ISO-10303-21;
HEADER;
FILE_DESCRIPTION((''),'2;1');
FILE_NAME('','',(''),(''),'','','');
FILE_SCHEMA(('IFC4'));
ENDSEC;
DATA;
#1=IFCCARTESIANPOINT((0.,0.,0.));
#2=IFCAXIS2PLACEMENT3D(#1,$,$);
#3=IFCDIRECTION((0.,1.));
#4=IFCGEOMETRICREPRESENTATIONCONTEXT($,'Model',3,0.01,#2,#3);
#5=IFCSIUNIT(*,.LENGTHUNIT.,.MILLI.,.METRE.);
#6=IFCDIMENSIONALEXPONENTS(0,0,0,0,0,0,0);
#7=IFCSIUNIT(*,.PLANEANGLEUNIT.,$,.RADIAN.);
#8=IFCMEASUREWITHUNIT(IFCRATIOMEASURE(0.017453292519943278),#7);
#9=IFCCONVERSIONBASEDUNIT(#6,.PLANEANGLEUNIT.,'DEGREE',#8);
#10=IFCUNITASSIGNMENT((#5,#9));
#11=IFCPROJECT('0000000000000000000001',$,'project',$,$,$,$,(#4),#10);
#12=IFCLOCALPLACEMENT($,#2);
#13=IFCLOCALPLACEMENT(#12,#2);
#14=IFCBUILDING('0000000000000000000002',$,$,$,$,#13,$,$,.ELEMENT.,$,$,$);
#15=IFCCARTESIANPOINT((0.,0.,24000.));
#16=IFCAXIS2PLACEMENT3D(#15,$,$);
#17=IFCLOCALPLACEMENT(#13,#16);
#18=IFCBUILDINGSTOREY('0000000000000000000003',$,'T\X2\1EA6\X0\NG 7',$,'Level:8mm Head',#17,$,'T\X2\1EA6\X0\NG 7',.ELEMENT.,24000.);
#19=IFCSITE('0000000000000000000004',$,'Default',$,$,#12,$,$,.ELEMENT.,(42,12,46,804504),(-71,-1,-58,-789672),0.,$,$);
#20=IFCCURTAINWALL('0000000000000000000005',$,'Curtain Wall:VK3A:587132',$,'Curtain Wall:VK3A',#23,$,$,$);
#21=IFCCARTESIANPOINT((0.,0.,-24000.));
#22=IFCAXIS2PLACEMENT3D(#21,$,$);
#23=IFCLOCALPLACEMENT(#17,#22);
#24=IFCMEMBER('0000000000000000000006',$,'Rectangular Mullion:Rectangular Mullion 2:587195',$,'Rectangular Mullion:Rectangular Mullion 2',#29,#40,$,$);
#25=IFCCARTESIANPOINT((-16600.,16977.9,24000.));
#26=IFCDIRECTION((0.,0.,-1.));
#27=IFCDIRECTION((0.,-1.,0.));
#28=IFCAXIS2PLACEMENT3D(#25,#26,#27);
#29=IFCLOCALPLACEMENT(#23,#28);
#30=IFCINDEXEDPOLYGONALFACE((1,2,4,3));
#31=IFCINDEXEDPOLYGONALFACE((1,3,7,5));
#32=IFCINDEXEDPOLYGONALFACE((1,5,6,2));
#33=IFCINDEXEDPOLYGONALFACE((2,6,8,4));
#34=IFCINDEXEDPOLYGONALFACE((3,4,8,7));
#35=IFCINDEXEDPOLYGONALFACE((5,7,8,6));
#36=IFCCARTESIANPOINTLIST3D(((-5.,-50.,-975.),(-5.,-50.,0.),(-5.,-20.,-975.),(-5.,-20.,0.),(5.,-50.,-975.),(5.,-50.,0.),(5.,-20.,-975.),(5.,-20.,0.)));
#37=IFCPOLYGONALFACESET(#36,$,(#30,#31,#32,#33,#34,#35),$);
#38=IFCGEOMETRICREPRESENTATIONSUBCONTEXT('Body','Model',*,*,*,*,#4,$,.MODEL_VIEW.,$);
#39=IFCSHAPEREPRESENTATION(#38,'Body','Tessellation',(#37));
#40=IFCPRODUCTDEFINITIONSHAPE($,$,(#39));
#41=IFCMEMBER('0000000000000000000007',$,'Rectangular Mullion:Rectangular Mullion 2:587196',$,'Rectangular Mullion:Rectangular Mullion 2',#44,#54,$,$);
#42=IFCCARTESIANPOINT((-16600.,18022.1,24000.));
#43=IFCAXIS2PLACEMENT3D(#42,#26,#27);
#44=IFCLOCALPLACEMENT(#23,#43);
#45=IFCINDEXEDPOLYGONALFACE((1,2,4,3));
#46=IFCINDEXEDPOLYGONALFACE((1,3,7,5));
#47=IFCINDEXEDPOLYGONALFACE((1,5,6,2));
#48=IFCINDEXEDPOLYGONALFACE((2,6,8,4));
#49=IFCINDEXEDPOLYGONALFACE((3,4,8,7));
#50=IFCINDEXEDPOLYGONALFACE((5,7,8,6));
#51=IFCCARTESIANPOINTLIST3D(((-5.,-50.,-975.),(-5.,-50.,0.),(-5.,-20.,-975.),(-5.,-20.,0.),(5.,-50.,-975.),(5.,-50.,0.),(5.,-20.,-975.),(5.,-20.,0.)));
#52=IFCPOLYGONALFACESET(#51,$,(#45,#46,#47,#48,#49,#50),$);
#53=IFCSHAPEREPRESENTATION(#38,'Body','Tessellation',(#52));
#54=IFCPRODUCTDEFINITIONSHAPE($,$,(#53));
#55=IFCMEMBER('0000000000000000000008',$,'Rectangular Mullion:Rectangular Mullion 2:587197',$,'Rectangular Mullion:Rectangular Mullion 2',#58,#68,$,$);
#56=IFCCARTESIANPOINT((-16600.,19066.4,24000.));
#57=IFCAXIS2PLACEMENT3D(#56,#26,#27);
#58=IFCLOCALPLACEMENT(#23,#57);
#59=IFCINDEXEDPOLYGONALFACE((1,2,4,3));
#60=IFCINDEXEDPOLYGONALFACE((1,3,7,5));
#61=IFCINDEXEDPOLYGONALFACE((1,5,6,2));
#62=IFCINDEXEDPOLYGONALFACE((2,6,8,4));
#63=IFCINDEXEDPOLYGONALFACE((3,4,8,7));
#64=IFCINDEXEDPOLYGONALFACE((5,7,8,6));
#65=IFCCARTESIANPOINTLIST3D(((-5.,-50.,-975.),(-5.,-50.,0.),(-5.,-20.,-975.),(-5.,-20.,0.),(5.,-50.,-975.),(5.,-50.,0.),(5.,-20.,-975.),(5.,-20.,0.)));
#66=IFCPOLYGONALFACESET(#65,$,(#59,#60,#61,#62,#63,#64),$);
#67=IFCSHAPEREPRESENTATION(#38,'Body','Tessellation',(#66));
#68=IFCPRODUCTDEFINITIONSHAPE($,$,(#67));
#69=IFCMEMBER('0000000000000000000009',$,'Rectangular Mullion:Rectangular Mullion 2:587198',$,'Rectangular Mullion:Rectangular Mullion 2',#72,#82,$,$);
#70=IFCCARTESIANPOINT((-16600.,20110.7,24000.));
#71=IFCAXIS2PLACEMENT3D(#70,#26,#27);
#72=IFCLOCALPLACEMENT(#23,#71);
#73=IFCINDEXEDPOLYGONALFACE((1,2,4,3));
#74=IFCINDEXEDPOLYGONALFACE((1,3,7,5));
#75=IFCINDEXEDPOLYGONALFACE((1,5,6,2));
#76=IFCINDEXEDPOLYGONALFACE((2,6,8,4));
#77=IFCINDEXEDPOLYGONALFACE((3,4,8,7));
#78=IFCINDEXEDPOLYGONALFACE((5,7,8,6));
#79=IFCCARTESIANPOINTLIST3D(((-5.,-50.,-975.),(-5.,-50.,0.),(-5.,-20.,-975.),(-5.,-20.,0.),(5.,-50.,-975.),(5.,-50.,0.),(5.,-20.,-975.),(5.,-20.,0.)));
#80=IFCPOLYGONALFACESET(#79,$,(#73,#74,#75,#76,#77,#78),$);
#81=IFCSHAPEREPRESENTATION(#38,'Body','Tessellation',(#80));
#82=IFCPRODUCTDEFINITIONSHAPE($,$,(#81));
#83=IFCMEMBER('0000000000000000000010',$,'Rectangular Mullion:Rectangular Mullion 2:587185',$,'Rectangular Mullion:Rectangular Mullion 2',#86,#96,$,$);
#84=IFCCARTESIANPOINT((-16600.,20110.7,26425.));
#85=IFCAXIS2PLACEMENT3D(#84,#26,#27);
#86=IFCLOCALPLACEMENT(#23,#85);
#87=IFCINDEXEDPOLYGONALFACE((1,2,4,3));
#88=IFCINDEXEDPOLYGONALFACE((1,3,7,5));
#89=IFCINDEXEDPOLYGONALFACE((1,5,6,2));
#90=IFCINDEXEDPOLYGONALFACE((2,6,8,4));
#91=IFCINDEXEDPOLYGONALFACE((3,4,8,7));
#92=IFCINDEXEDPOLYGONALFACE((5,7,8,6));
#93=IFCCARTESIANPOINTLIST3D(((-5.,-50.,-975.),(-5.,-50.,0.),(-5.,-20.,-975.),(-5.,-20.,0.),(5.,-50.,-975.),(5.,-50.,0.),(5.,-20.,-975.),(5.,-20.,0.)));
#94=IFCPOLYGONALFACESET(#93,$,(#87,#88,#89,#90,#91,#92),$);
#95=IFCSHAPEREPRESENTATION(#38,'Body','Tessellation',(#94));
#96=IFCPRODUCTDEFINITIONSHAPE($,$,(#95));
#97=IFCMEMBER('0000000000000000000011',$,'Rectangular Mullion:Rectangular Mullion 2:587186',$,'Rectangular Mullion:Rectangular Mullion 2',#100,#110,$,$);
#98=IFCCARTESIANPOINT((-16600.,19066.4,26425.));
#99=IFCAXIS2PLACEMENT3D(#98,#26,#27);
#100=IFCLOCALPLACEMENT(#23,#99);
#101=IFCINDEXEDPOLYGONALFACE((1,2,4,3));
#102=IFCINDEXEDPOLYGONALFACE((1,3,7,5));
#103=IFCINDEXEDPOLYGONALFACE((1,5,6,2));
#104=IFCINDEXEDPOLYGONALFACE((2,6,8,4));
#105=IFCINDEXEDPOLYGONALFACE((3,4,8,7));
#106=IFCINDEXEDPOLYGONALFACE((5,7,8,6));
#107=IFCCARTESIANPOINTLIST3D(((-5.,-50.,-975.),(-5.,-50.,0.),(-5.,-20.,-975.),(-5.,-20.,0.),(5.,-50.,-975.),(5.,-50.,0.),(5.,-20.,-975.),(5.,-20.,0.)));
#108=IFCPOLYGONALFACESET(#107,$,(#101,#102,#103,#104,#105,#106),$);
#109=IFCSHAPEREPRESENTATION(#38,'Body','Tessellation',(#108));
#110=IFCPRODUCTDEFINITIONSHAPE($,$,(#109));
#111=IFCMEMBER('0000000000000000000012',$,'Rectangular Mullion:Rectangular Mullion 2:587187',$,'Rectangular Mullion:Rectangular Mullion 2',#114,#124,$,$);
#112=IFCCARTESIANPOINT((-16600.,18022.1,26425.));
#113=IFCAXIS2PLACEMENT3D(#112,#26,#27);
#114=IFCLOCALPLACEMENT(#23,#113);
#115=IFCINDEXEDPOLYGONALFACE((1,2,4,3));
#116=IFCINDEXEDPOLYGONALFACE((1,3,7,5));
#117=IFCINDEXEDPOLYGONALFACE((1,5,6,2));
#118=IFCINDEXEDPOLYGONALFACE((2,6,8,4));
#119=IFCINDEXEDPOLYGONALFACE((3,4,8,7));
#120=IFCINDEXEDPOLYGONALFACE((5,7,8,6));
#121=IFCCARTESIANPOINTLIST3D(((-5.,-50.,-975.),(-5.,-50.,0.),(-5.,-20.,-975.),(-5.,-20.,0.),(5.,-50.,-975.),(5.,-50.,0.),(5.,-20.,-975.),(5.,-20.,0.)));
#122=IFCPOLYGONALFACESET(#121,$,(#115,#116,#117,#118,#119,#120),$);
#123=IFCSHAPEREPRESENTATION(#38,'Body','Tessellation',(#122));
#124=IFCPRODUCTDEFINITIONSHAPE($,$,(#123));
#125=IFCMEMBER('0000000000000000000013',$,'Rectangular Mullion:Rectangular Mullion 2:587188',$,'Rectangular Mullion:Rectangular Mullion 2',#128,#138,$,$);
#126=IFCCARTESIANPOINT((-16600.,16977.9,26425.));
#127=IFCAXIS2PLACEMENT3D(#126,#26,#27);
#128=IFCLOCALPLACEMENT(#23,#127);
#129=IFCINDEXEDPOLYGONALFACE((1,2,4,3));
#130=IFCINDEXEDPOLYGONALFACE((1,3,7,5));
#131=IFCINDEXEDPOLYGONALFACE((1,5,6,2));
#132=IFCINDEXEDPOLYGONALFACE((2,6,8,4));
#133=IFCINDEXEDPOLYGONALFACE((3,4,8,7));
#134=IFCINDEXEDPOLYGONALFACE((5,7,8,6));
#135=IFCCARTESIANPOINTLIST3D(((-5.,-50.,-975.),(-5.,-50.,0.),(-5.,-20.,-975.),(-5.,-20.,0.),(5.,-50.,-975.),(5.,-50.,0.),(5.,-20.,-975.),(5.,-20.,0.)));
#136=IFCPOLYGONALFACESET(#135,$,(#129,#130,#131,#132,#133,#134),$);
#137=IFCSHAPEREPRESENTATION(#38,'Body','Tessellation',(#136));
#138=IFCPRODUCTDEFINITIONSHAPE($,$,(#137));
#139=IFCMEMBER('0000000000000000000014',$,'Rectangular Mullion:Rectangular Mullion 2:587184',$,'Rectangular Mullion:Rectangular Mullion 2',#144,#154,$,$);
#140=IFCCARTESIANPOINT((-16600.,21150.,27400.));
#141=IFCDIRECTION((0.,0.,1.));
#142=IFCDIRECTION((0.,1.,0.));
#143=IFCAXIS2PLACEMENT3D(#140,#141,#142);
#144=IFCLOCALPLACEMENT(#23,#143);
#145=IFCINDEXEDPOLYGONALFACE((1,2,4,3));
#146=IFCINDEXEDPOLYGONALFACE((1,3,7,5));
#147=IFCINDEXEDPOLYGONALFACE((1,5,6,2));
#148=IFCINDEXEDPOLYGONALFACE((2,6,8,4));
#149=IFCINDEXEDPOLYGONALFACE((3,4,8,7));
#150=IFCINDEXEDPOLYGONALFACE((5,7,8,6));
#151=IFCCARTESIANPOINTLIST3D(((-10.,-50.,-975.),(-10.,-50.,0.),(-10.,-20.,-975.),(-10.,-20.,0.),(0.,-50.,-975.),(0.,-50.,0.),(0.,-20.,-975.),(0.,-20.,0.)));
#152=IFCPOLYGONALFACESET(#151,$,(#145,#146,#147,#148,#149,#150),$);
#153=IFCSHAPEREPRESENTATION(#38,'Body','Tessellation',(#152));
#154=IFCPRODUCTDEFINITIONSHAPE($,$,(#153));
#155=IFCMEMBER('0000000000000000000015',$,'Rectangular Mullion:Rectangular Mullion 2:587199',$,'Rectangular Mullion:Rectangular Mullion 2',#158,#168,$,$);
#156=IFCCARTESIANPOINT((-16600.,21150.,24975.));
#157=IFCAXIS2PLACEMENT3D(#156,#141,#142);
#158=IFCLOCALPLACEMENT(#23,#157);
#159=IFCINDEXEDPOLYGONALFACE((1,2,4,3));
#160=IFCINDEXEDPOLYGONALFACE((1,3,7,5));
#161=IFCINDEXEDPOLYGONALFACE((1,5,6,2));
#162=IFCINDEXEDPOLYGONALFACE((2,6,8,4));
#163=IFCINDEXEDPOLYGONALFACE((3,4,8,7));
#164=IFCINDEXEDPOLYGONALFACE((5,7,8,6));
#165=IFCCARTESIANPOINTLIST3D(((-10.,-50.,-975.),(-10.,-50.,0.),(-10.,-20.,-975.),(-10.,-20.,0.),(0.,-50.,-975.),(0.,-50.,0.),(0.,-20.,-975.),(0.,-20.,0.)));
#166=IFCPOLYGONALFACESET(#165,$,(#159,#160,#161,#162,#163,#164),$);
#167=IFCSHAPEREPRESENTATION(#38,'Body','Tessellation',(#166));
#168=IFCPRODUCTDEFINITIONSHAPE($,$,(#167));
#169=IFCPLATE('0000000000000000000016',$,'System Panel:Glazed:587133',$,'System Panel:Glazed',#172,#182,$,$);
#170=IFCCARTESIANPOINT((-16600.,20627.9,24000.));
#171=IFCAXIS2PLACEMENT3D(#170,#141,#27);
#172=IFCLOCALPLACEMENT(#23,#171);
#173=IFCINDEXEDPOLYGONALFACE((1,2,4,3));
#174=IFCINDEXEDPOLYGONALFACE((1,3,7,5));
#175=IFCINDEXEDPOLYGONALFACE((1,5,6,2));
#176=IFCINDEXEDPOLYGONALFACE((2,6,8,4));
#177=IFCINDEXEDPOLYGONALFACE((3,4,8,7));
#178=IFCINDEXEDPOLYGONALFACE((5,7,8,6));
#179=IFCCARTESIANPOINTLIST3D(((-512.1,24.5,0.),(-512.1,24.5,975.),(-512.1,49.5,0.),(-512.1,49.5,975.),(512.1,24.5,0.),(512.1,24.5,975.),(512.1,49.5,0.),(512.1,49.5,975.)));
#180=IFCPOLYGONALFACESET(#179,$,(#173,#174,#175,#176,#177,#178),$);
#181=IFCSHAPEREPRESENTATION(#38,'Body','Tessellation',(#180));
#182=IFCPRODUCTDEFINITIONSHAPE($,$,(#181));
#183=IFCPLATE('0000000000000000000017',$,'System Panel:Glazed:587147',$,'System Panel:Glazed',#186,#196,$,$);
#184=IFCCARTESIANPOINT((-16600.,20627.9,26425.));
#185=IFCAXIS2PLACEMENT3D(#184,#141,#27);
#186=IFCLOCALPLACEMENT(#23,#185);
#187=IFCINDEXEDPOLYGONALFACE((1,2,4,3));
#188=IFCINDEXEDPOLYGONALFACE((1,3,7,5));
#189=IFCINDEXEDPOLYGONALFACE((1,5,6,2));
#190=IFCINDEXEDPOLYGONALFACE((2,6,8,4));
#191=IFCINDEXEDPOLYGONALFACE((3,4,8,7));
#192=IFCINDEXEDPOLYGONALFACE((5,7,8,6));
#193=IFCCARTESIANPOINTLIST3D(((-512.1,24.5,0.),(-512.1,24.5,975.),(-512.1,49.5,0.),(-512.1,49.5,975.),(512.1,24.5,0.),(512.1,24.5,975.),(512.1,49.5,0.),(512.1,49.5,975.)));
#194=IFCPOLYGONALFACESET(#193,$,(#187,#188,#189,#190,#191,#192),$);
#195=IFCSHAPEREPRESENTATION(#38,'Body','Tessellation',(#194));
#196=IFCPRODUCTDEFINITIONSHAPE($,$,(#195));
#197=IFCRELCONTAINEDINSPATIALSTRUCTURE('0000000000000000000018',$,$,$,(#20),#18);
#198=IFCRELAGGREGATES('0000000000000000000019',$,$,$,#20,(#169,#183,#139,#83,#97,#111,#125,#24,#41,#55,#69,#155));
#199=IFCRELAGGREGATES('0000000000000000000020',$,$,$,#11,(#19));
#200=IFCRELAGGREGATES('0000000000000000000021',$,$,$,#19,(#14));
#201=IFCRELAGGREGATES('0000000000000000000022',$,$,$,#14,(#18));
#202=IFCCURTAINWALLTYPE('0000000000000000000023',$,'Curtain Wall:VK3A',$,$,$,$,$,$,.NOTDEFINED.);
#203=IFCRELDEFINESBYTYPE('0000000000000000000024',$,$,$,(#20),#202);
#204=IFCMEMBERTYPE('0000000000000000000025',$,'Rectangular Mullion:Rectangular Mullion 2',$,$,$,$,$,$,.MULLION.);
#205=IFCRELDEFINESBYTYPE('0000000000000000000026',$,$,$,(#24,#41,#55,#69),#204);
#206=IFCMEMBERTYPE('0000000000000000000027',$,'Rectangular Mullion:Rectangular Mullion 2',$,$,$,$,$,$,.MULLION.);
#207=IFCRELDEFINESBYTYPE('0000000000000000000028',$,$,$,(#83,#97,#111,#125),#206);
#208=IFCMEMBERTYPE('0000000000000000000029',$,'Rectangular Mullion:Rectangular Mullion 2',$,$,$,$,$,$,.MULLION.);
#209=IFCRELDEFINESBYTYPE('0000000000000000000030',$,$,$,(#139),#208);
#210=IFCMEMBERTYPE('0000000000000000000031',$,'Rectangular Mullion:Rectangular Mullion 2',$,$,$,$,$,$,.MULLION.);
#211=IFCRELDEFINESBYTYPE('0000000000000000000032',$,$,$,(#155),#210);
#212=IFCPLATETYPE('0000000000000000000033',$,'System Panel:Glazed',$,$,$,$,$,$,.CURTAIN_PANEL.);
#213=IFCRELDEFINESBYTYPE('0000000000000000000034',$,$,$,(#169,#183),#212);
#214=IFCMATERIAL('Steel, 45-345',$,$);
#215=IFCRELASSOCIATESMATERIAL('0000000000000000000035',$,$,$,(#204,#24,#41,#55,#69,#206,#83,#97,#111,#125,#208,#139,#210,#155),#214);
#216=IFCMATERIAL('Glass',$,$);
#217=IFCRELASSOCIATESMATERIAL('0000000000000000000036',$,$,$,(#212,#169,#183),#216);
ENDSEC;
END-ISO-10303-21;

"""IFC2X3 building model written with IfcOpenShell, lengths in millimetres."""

from ifc_helpers import new_model, entity, si_unit, converted_unit, direction, frame, frame_2d, origin, origin_2d_with_axis, place, context, subcontext, project, spatial, rectangle, extrude, source, transform, mapped, material, type_object, type_shapes, element, aggregate, save


model = new_model("IFC2X3")

# Units and contexts
model_context = context("Model", 3, precision=0.01, world=origin(), true_north=direction((0.0, 1.0)))
body_context = subcontext(model_context, "Body", "Model", "MODEL_VIEW")
ifc_project = project(units=[si_unit("LENGTHUNIT", "METRE", prefix="MILLI"), converted_unit("PLANEANGLEUNIT", "DEGREE", entity("IfcRatioMeasure", 0.017453292519943278), si_unit("PLANEANGLEUNIT", "RADIAN"), dimensions=[0, 0, 0, 0, 0, 0, 0])], contexts=[model_context])

# Site, building, storey
site_placement = place(None, origin())
site = spatial("IfcSite", under=ifc_project, at=site_placement, Name="Default", CompositionType="ELEMENT", RefLatitude=(42, 12, 46, 804504), RefLongitude=(-71, -1, -58, -789672), RefElevation=0.0)
building_placement = place(site_placement, origin())
building = spatial("IfcBuilding", under=site, at=building_placement, CompositionType="ELEMENT")
storey_placement = place(building_placement, frame((0.0, 0.0, 24000.0)))
storey = spatial("IfcBuildingStorey", under=building, at=storey_placement, Name="TẦNG 7", ObjectType="Level:8mm Head", LongName="TẦNG 7", CompositionType="ELEMENT", Elevation=24000.0)

# Curtain wall, members
curtain_wall_type_1 = type_object("IfcCurtainWallType", Name="Curtain Wall:VK3A", PredefinedType="NOTDEFINED")
curtain_wall_1_placement = place(storey_placement, frame((0.0, 0.0, -24000.0)))
curtain_wall_1 = element("IfcCurtainWall", 1, at=curtain_wall_1_placement, inside=storey, type_object=curtain_wall_type_1, Name="Curtain Wall:VK3A:587132", ObjectType="Curtain Wall:VK3A")
ifc_material_1 = material(Name="Steel, 45-345")
member_type_1 = type_object("IfcMemberType", Name="Rectangular Mullion:Rectangular Mullion 2", PredefinedType="MULLION", material=ifc_material_1)
shared_shape_1 = source(origin(), body_context, "Body", "SweptSolid", [
    extrude(rectangle(XDim=30.0, YDim=10.0, at=frame_2d((0.0, 0.0), x_axis=(1.0, 0.0))), frame((0.0, -35.0, -975.0), z_axis=(0.0, 0.0, 1.0), x_axis=(0.0, -1.0, 0.0)), (0.0, 0.0, 1.0), 975.0),
])
type_shapes(member_type_1, [shared_shape_1])
member_1_placement = place(curtain_wall_1_placement, frame((-16600.0, 16977.9, 24000.0), z_axis=(0.0, 0.0, -1.0), x_axis=(0.0, -1.0, 0.0)))
member_1 = element("IfcMember", 2, at=member_1_placement, type_object=member_type_1, material=ifc_material_1, Name="Rectangular Mullion:Rectangular Mullion 2:587195", ObjectType="Rectangular Mullion:Rectangular Mullion 2", context=body_context, shape_type="MappedRepresentation", body=[
    mapped(shared_shape_1, transform((0.0, 0.0, 0.0), scale=1.0)),
])
member_2_placement = place(curtain_wall_1_placement, frame((-16600.0, 18022.1, 24000.0), z_axis=(0.0, 0.0, -1.0), x_axis=(0.0, -1.0, 0.0)))
member_2 = element("IfcMember", 3, at=member_2_placement, type_object=member_type_1, material=ifc_material_1, Name="Rectangular Mullion:Rectangular Mullion 2:587196", ObjectType="Rectangular Mullion:Rectangular Mullion 2", context=body_context, shape_type="MappedRepresentation", body=[
    mapped(shared_shape_1, transform((0.0, 0.0, 0.0), scale=1.0)),
])
member_3_placement = place(curtain_wall_1_placement, frame((-16600.0, 19066.4, 24000.0), z_axis=(0.0, 0.0, -1.0), x_axis=(0.0, -1.0, 0.0)))
member_3 = element("IfcMember", 4, at=member_3_placement, type_object=member_type_1, material=ifc_material_1, Name="Rectangular Mullion:Rectangular Mullion 2:587197", ObjectType="Rectangular Mullion:Rectangular Mullion 2", context=body_context, shape_type="MappedRepresentation", body=[
    mapped(shared_shape_1, transform((0.0, 0.0, 0.0), scale=1.0)),
])
member_4_placement = place(curtain_wall_1_placement, frame((-16600.0, 20110.7, 24000.0), z_axis=(0.0, 0.0, -1.0), x_axis=(0.0, -1.0, 0.0)))
member_4 = element("IfcMember", 5, at=member_4_placement, type_object=member_type_1, material=ifc_material_1, Name="Rectangular Mullion:Rectangular Mullion 2:587198", ObjectType="Rectangular Mullion:Rectangular Mullion 2", context=body_context, shape_type="MappedRepresentation", body=[
    mapped(shared_shape_1, transform((0.0, 0.0, 0.0), scale=1.0)),
])

# Members
member_type_2 = type_object("IfcMemberType", Name="Rectangular Mullion:Rectangular Mullion 2", PredefinedType="MULLION", material=ifc_material_1)
shared_shape_2 = source(origin(), body_context, "Body", "SweptSolid", [
    extrude(rectangle(XDim=30.0, YDim=10.0, at=frame_2d((0.0, 0.0), x_axis=(1.0, 0.0))), frame((0.0, -35.0, -975.0), z_axis=(0.0, 0.0, 1.0), x_axis=(0.0, -1.0, 0.0)), (0.0, 0.0, 1.0), 975.0),
])
type_shapes(member_type_2, [shared_shape_2])
member_5_placement = place(curtain_wall_1_placement, frame((-16600.0, 20110.7, 26425.0), z_axis=(0.0, 0.0, -1.0), x_axis=(0.0, -1.0, 0.0)))
member_5 = element("IfcMember", 6, at=member_5_placement, type_object=member_type_2, material=ifc_material_1, Name="Rectangular Mullion:Rectangular Mullion 2:587185", ObjectType="Rectangular Mullion:Rectangular Mullion 2", context=body_context, shape_type="MappedRepresentation", body=[
    mapped(shared_shape_2, transform((0.0, 0.0, 0.0), scale=1.0)),
])
member_6_placement = place(curtain_wall_1_placement, frame((-16600.0, 19066.4, 26425.0), z_axis=(0.0, 0.0, -1.0), x_axis=(0.0, -1.0, 0.0)))
member_6 = element("IfcMember", 7, at=member_6_placement, type_object=member_type_2, material=ifc_material_1, Name="Rectangular Mullion:Rectangular Mullion 2:587186", ObjectType="Rectangular Mullion:Rectangular Mullion 2", context=body_context, shape_type="MappedRepresentation", body=[
    mapped(shared_shape_2, transform((0.0, 0.0, 0.0), scale=1.0)),
])
member_7_placement = place(curtain_wall_1_placement, frame((-16600.0, 18022.1, 26425.0), z_axis=(0.0, 0.0, -1.0), x_axis=(0.0, -1.0, 0.0)))
member_7 = element("IfcMember", 8, at=member_7_placement, type_object=member_type_2, material=ifc_material_1, Name="Rectangular Mullion:Rectangular Mullion 2:587187", ObjectType="Rectangular Mullion:Rectangular Mullion 2", context=body_context, shape_type="MappedRepresentation", body=[
    mapped(shared_shape_2, transform((0.0, 0.0, 0.0), scale=1.0)),
])
member_8_placement = place(curtain_wall_1_placement, frame((-16600.0, 16977.9, 26425.0), z_axis=(0.0, 0.0, -1.0), x_axis=(0.0, -1.0, 0.0)))
member_8 = element("IfcMember", 9, at=member_8_placement, type_object=member_type_2, material=ifc_material_1, Name="Rectangular Mullion:Rectangular Mullion 2:587188", ObjectType="Rectangular Mullion:Rectangular Mullion 2", context=body_context, shape_type="MappedRepresentation", body=[
    mapped(shared_shape_2, transform((0.0, 0.0, 0.0), scale=1.0)),
])
member_type_3 = type_object("IfcMemberType", Name="Rectangular Mullion:Rectangular Mullion 2", PredefinedType="MULLION", material=ifc_material_1)
shared_shape_3 = source(origin(), body_context, "Body", "SweptSolid", [
    extrude(rectangle(XDim=30.0, YDim=10.0, at=frame_2d((0.0, 0.0), x_axis=(1.0, 0.0))), frame((-5.0, -35.0, -975.0), z_axis=(0.0, 0.0, 1.0), x_axis=(0.0, -1.0, 0.0)), (0.0, 0.0, 1.0), 975.0),
])
type_shapes(member_type_3, [shared_shape_3])
member_9_placement = place(curtain_wall_1_placement, frame((-16600.0, 21150.0, 27400.0), z_axis=(0.0, 0.0, 1.0), x_axis=(0.0, 1.0, 0.0)))
member_9 = element("IfcMember", 10, at=member_9_placement, type_object=member_type_3, material=ifc_material_1, Name="Rectangular Mullion:Rectangular Mullion 2:587184", ObjectType="Rectangular Mullion:Rectangular Mullion 2", context=body_context, shape_type="MappedRepresentation", body=[
    mapped(shared_shape_3, transform((0.0, 0.0, 0.0), scale=1.0)),
])
member_type_4 = type_object("IfcMemberType", Name="Rectangular Mullion:Rectangular Mullion 2", PredefinedType="MULLION", material=ifc_material_1)
shared_shape_4 = source(origin(), body_context, "Body", "SweptSolid", [
    extrude(rectangle(XDim=30.0, YDim=10.0, at=frame_2d((0.0, 0.0), x_axis=(1.0, 0.0))), frame((-5.0, -35.0, -975.0), z_axis=(0.0, 0.0, 1.0), x_axis=(0.0, -1.0, 0.0)), (0.0, 0.0, 1.0), 975.0),
])
type_shapes(member_type_4, [shared_shape_4])
member_10_placement = place(curtain_wall_1_placement, frame((-16600.0, 21150.0, 24975.0), z_axis=(0.0, 0.0, 1.0), x_axis=(0.0, 1.0, 0.0)))
member_10 = element("IfcMember", 11, at=member_10_placement, type_object=member_type_4, material=ifc_material_1, Name="Rectangular Mullion:Rectangular Mullion 2:587199", ObjectType="Rectangular Mullion:Rectangular Mullion 2", context=body_context, shape_type="MappedRepresentation", body=[
    mapped(shared_shape_4, transform((0.0, 0.0, 0.0), scale=1.0)),
])

# Plates
ifc_material_2 = material(Name="Glass")
plate_type_1 = type_object("IfcPlateType", Name="System Panel:Glazed", PredefinedType="CURTAIN_PANEL", material=ifc_material_2)
shared_shape_5 = source(origin(), body_context, "Body", "SweptSolid", [
    extrude(rectangle(XDim=25.0, YDim=1024.3, at=origin_2d_with_axis()), frame((0.0, 37.0, 0.0), z_axis=(0.0, 0.0, 1.0), x_axis=(0.0, 1.0, 0.0)), (0.0, 0.0, 1.0), 975.0),
])
type_shapes(plate_type_1, [shared_shape_5])
plate_1_placement = place(curtain_wall_1_placement, frame((-16600.0, 20627.9, 24000.0), z_axis=(0.0, 0.0, 1.0), x_axis=(0.0, -1.0, 0.0)))
plate_1 = element("IfcPlate", 12, at=plate_1_placement, type_object=plate_type_1, material=ifc_material_2, Name="System Panel:Glazed:587133", ObjectType="System Panel:Glazed", context=body_context, shape_type="MappedRepresentation", body=[
    mapped(shared_shape_5, transform((0.0, 0.0, 0.0), scale=1.0)),
])
plate_2_placement = place(curtain_wall_1_placement, frame((-16600.0, 20627.9, 26425.0), z_axis=(0.0, 0.0, 1.0), x_axis=(0.0, -1.0, 0.0)))
plate_2 = element("IfcPlate", 13, at=plate_2_placement, type_object=plate_type_1, material=ifc_material_2, Name="System Panel:Glazed:587147", ObjectType="System Panel:Glazed", context=body_context, shape_type="MappedRepresentation", body=[
    mapped(shared_shape_5, transform((0.0, 0.0, 0.0), scale=1.0)),
])
aggregate(curtain_wall_1, [plate_1, plate_2, member_9, member_5, member_6, member_7, member_8, member_1, member_2, member_3, member_4, member_10])

save(model, "model.ifc")
